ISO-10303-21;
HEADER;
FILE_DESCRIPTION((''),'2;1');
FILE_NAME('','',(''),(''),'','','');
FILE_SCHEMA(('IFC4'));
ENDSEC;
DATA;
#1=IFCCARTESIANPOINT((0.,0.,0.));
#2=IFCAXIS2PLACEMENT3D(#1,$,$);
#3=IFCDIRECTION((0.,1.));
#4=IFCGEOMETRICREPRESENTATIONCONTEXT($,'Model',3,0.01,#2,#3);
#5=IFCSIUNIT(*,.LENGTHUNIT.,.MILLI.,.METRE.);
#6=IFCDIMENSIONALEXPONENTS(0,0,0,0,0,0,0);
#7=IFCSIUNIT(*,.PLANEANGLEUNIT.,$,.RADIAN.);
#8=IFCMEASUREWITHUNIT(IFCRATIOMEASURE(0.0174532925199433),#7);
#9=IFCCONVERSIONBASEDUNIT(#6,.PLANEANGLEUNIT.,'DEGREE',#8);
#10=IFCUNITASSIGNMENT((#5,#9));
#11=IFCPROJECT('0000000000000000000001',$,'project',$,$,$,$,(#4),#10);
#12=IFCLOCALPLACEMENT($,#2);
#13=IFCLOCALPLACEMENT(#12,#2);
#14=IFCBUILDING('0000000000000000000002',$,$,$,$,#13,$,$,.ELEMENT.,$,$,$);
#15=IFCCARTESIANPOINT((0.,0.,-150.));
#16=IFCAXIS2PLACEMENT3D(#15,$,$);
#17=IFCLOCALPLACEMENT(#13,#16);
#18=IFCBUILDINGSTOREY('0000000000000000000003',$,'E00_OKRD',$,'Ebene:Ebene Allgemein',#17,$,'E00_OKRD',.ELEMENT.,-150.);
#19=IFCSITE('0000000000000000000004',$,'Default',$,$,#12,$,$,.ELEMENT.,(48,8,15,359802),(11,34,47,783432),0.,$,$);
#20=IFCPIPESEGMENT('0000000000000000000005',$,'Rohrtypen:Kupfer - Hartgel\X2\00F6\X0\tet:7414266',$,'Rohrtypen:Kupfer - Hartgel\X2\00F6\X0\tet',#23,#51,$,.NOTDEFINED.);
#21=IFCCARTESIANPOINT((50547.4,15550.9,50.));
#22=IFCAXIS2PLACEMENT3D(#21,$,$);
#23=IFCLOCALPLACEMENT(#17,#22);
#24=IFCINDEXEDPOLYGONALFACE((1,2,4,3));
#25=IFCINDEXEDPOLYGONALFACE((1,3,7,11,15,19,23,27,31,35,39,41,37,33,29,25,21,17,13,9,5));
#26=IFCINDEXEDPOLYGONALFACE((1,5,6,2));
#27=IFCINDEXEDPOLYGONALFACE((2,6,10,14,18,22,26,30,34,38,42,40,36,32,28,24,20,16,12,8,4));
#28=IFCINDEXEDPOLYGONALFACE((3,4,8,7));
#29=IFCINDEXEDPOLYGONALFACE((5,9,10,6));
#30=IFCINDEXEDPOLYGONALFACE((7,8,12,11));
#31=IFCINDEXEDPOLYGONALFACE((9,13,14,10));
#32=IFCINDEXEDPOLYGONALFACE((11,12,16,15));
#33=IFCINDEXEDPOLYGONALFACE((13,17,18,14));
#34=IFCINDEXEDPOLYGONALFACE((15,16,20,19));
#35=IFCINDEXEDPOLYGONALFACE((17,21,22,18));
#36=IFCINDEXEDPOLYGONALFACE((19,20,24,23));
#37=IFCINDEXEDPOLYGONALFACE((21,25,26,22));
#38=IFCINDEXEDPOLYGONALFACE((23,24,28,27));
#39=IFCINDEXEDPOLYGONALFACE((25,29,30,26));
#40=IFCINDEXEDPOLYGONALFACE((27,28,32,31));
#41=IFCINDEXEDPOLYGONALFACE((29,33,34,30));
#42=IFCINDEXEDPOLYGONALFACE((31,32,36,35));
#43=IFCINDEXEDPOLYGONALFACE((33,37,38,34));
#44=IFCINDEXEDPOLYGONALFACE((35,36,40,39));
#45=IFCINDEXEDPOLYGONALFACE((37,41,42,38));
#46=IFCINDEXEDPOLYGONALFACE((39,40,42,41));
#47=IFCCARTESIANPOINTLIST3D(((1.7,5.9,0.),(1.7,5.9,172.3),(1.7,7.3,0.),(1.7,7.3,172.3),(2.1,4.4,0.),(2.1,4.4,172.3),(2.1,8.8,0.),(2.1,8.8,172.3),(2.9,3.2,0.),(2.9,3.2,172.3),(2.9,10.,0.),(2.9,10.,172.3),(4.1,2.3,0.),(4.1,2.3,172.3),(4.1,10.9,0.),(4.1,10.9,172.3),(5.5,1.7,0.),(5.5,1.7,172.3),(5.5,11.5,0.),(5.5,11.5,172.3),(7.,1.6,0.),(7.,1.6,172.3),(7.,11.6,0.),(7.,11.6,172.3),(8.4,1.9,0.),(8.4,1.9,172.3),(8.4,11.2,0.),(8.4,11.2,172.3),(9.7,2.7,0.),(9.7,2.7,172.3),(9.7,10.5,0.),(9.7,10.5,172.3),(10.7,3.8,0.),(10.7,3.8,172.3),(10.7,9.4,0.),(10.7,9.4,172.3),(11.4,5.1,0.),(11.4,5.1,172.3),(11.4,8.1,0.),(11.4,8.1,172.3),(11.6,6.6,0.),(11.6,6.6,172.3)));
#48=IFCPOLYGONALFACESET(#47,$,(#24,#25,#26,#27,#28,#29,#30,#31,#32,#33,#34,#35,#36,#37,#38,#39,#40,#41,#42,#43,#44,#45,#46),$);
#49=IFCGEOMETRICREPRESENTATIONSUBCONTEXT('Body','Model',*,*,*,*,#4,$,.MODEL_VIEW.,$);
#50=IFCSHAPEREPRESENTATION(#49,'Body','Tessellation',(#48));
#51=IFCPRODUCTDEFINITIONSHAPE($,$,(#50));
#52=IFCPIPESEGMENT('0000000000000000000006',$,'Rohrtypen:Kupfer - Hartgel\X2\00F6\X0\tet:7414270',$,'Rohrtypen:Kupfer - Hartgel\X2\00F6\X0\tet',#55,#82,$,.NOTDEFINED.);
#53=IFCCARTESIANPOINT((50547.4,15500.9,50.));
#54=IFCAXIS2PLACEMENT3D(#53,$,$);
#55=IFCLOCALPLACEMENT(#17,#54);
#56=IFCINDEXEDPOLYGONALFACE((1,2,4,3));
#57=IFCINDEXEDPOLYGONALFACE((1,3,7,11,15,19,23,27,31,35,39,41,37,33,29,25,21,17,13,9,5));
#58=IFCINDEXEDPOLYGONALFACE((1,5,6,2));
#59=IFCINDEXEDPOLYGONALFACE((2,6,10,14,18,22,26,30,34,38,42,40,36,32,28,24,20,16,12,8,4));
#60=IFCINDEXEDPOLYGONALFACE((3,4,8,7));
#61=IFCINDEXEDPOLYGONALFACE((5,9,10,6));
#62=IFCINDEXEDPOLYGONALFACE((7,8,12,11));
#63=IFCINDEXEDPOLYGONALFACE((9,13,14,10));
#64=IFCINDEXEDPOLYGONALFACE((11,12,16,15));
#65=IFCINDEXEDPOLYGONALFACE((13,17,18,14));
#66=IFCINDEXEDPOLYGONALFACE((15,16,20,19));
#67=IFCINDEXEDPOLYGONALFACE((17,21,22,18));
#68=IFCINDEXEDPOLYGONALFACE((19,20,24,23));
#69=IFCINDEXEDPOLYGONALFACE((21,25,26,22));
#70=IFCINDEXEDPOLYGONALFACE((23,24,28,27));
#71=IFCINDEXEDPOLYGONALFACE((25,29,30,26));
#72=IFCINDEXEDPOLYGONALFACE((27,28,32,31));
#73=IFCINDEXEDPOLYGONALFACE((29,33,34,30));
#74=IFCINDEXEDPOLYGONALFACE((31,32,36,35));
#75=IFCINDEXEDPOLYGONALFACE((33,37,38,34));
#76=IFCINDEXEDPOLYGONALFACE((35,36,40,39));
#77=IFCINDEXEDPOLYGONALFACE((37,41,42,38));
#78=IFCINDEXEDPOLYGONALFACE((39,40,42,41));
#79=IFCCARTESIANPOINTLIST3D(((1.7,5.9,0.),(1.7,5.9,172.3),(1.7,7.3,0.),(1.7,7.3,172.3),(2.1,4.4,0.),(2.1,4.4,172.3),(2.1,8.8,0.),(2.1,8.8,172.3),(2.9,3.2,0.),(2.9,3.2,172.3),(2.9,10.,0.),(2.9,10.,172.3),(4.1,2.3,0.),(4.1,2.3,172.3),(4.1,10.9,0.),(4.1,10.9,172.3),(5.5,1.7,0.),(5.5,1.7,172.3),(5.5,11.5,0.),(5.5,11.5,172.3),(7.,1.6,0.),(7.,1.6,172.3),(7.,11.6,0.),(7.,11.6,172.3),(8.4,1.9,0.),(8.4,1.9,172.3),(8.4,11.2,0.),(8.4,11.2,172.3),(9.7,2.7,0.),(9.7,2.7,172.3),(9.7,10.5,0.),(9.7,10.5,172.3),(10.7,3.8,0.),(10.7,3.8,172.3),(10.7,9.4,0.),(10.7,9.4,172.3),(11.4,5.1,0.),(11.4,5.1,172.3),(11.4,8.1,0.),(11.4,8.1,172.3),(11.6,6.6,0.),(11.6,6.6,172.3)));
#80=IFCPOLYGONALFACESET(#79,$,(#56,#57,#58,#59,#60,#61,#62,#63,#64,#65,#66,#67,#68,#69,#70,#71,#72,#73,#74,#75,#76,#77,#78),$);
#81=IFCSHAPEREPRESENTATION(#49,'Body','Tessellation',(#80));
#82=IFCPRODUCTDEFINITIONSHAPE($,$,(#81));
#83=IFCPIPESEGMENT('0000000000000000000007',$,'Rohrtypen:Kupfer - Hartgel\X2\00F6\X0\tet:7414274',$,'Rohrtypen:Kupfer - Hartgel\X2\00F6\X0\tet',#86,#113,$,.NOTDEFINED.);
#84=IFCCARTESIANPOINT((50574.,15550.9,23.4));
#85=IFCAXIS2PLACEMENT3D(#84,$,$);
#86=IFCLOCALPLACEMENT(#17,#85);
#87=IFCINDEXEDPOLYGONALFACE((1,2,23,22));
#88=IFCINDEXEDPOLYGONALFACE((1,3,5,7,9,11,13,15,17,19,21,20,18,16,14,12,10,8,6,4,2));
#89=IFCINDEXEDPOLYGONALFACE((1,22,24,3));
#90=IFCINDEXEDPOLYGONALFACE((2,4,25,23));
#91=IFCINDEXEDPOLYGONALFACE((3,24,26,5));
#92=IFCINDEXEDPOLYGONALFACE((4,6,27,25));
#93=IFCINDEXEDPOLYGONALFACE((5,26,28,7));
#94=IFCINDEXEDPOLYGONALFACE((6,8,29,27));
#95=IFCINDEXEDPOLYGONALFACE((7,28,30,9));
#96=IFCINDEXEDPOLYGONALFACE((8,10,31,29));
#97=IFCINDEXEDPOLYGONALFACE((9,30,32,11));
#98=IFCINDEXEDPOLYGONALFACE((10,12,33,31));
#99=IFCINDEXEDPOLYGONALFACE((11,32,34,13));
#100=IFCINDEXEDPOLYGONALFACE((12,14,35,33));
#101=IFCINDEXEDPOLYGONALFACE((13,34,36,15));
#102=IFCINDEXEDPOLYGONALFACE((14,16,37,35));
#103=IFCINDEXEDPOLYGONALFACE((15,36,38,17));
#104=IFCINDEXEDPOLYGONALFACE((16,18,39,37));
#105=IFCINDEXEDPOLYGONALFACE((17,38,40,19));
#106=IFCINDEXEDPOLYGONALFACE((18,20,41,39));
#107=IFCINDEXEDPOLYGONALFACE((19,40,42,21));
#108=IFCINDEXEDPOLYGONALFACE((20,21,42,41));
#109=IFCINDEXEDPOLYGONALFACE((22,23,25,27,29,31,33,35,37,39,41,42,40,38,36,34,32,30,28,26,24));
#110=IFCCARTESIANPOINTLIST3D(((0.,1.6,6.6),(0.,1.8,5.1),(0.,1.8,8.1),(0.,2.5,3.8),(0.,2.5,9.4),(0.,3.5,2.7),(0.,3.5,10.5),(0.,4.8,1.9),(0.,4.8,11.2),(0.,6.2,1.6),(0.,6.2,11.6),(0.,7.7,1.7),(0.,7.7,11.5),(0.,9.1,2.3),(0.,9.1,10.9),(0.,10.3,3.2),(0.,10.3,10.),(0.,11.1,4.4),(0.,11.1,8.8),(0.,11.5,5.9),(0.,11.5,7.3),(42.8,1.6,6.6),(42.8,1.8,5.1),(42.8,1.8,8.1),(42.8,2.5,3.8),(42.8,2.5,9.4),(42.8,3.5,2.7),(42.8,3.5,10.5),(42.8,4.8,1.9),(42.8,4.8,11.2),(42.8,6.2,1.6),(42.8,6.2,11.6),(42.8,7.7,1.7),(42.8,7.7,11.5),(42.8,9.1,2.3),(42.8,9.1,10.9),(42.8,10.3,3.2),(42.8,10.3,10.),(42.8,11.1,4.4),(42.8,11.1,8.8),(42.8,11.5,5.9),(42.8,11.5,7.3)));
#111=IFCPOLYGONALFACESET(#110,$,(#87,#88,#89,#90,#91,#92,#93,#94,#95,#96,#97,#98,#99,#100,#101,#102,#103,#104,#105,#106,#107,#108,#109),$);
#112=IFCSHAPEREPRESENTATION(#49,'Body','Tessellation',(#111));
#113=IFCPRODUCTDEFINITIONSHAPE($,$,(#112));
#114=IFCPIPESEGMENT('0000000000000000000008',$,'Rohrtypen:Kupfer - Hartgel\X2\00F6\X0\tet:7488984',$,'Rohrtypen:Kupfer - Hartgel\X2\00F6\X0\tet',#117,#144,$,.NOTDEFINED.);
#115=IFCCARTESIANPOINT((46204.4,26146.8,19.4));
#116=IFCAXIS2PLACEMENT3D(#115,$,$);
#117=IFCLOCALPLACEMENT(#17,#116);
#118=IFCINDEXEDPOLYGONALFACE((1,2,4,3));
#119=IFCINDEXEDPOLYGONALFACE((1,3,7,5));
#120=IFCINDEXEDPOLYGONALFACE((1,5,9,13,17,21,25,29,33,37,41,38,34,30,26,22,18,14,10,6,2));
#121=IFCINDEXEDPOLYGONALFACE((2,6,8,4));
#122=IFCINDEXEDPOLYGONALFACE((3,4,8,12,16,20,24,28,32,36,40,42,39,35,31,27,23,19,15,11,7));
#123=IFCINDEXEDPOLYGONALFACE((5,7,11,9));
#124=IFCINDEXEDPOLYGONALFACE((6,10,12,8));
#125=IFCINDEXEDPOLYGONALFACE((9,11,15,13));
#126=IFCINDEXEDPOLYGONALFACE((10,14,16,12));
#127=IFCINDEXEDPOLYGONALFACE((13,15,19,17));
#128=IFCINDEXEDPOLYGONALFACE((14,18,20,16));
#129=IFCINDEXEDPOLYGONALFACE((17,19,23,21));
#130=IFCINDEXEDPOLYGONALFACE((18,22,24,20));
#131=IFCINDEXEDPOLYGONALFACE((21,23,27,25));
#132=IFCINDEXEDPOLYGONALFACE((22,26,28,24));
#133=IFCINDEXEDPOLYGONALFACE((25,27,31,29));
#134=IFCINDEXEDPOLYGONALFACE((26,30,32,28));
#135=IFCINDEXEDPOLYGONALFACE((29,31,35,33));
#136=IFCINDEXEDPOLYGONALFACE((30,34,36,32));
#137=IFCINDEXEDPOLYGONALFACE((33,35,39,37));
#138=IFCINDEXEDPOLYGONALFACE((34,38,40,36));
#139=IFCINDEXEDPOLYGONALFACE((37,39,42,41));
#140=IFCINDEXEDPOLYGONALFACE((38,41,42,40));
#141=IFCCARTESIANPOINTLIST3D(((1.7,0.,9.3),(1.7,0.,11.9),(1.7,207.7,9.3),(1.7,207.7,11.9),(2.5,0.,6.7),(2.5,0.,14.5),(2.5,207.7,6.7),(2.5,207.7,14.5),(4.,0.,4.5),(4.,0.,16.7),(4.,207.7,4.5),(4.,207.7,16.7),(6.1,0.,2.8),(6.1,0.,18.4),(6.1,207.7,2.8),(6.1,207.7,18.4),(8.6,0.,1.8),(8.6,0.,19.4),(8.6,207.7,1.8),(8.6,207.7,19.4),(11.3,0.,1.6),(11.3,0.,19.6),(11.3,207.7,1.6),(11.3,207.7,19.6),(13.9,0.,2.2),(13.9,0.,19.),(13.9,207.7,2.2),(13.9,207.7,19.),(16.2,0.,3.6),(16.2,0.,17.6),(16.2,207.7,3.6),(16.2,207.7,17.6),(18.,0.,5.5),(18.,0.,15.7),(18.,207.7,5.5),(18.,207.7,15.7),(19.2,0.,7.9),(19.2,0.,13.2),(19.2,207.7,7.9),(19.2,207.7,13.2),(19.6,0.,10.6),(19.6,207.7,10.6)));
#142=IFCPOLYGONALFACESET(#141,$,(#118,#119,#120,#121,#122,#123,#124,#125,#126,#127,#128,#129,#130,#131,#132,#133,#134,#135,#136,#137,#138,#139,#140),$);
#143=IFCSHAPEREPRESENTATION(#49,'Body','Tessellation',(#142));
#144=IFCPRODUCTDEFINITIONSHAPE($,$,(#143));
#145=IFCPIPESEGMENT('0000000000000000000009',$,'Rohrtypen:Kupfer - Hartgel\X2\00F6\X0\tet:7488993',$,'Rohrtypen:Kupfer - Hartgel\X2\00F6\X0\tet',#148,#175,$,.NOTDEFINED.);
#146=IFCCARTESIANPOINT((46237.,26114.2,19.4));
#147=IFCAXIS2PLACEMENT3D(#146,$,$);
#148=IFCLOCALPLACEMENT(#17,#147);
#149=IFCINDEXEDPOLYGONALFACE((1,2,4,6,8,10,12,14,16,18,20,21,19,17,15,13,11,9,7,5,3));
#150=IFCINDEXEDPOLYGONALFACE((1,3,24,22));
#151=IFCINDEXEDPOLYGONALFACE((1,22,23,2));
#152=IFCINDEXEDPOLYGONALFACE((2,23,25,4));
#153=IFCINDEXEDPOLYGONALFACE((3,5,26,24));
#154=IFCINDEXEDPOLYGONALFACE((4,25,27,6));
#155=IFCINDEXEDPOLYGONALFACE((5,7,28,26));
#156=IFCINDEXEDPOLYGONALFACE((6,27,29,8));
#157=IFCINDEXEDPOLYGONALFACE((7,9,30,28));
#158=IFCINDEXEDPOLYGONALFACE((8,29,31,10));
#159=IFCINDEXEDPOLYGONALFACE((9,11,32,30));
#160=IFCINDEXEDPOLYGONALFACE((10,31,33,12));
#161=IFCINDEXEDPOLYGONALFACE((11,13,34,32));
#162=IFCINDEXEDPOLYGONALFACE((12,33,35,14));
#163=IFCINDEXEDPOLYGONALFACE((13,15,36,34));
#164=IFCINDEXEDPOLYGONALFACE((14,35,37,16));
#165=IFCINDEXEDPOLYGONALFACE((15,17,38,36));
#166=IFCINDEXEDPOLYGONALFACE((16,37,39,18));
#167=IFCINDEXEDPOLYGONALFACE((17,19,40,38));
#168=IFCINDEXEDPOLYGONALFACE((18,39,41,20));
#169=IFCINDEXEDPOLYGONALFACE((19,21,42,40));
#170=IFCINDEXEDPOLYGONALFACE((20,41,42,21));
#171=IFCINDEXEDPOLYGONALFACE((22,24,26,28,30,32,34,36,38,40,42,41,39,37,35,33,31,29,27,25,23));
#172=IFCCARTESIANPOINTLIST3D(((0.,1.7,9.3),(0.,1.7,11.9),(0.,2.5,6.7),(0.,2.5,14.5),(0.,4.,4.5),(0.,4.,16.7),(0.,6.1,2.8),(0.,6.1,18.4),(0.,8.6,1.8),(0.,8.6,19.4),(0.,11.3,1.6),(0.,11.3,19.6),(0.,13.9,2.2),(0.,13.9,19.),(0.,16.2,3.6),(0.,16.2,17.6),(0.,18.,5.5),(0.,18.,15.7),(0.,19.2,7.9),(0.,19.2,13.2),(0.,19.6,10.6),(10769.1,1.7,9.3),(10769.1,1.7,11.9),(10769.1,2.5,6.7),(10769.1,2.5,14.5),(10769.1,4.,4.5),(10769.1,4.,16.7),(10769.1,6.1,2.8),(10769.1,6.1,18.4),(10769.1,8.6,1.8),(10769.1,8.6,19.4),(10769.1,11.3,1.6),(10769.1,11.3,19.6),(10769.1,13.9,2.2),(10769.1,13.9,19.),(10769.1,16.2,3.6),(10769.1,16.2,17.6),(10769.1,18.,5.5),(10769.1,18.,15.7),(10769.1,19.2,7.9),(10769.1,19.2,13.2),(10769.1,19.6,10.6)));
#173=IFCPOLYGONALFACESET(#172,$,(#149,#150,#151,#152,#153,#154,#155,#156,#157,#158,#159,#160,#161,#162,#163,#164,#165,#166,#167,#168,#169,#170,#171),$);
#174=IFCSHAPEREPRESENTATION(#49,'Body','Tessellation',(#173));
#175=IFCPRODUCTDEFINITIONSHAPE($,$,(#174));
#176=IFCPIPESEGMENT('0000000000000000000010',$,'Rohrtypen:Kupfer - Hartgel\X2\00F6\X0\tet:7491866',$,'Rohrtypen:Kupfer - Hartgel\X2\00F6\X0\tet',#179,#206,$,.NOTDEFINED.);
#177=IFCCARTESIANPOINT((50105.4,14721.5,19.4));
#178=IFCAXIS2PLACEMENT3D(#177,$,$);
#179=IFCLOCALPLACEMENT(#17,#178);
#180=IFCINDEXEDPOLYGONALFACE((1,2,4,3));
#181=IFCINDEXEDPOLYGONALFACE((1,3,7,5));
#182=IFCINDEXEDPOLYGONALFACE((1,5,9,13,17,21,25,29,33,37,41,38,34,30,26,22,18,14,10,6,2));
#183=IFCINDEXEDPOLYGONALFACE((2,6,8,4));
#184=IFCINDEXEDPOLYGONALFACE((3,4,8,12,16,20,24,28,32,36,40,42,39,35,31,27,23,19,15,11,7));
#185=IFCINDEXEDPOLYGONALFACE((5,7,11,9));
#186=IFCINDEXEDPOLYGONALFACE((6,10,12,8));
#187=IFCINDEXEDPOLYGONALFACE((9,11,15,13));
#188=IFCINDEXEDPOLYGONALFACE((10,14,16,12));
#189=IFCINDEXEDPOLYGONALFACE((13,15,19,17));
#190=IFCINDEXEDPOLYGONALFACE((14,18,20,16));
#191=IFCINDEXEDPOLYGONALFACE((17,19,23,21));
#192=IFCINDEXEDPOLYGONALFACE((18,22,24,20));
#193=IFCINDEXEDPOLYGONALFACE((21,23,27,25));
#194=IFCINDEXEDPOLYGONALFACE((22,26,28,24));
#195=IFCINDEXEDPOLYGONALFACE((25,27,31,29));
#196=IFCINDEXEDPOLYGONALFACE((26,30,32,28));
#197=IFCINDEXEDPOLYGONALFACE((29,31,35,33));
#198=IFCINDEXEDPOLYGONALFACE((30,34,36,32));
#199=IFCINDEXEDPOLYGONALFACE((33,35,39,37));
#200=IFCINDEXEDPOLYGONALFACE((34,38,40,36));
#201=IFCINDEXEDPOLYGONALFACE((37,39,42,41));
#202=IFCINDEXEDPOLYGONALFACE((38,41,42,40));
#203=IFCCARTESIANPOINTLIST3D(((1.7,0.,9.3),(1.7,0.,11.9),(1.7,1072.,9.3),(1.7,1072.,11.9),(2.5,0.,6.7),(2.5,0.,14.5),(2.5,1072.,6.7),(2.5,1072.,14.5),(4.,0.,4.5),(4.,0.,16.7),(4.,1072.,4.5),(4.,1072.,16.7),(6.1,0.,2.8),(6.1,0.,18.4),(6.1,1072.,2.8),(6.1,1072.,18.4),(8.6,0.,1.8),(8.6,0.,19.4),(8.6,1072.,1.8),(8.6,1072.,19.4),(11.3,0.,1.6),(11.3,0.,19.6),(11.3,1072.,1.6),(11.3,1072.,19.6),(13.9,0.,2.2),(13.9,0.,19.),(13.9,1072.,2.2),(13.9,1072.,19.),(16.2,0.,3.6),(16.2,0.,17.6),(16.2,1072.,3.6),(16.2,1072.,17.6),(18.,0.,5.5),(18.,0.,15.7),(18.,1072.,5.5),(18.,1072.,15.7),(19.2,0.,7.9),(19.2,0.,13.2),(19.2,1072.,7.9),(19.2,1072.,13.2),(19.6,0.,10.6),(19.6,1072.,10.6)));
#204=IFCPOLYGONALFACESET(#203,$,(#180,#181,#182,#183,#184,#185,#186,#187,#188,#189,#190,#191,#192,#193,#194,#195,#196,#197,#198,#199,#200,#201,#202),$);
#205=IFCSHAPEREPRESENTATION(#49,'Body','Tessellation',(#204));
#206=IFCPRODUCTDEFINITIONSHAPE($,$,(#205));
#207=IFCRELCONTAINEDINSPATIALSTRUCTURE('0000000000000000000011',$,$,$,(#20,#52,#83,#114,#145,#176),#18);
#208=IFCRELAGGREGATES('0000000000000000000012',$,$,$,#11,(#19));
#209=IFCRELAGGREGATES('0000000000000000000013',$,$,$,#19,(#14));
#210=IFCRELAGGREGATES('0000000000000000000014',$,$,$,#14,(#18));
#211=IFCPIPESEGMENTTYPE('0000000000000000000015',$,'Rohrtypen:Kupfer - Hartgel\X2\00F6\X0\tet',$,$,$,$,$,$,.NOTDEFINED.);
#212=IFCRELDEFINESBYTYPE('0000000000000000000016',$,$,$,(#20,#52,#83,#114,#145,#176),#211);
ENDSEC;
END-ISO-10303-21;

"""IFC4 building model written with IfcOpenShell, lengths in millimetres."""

from ifc_helpers import new_model, entity, si_unit, converted_unit, direction, frame, frame_2d, origin, origin_2d_with_axis, place, context, subcontext, project, spatial, circle, extrude, type_object, element, save


model = new_model("IFC4")

# Units and contexts
model_context = context("Model", 3, precision=0.01, world=origin(), true_north=direction((0.0, 1.0)))
body_context = subcontext(model_context, "Body", "Model", "MODEL_VIEW")
ifc_project = project(units=[si_unit("LENGTHUNIT", "METRE", prefix="MILLI"), converted_unit("PLANEANGLEUNIT", "DEGREE", entity("IfcRatioMeasure", 0.0174532925199433), si_unit("PLANEANGLEUNIT", "RADIAN"), dimensions=[0, 0, 0, 0, 0, 0, 0])], contexts=[model_context])

# Site, building, storey
site_placement = place(None, origin())
site = spatial("IfcSite", under=ifc_project, at=site_placement, Name="Default", CompositionType="ELEMENT", RefLatitude=(48, 8, 15, 359802), RefLongitude=(11, 34, 47, 783432), RefElevation=0.0)
building_placement = place(site_placement, origin())
building = spatial("IfcBuilding", under=site, at=building_placement, CompositionType="ELEMENT")
storey_placement = place(building_placement, frame((0.0, 0.0, -150.0)))
storey = spatial("IfcBuildingStorey", under=building, at=storey_placement, Name="E00_OKRD", ObjectType="Ebene:Ebene Allgemein", LongName="E00_OKRD", CompositionType="ELEMENT", Elevation=-150.0)

# Pipe segments
pipe_segment_type = type_object("IfcPipeSegmentType", Name="Rohrtypen:Kupfer - Hartgelötet", PredefinedType="NOTDEFINED")
pipe_segment_1_placement = place(storey_placement, frame((50547.4, 15550.9, 50.0)))
element("IfcPipeSegment", 1, at=pipe_segment_1_placement, inside=storey, type_object=pipe_segment_type, Name="Rohrtypen:Kupfer - Hartgelötet:7414266", ObjectType="Rohrtypen:Kupfer - Hartgelötet", PredefinedType="NOTDEFINED", context=body_context, shape_type="SweptSolid", body=[
    extrude(circle(Radius=5.0, at=origin_2d_with_axis()), frame((6.6, 6.6, 0.0)), (0.0, 0.0, 1.0), 172.3),
])
pipe_segment_2_placement = place(storey_placement, frame((50547.4, 15500.9, 50.0)))
element("IfcPipeSegment", 2, at=pipe_segment_2_placement, inside=storey, type_object=pipe_segment_type, Name="Rohrtypen:Kupfer - Hartgelötet:7414270", ObjectType="Rohrtypen:Kupfer - Hartgelötet", PredefinedType="NOTDEFINED", context=body_context, shape_type="SweptSolid", body=[
    extrude(circle(Radius=5.0, at=origin_2d_with_axis()), frame((6.6, 6.6, 0.0)), (0.0, 0.0, 1.0), 172.3),
])
pipe_segment_3_placement = place(storey_placement, frame((50574.0, 15550.9, 23.4)))
element("IfcPipeSegment", 3, at=pipe_segment_3_placement, inside=storey, type_object=pipe_segment_type, Name="Rohrtypen:Kupfer - Hartgelötet:7414274", ObjectType="Rohrtypen:Kupfer - Hartgelötet", PredefinedType="NOTDEFINED", context=body_context, shape_type="SweptSolid", body=[
    extrude(circle(Radius=5.0, at=origin_2d_with_axis()), frame((0.0, 6.6, 6.6), z_axis=(1.0, 0.0, 0.0), x_axis=(0.0, -1.0, 0.0)), (0.0, 0.0, 1.0), 42.8),
])
pipe_segment_4_placement = place(storey_placement, frame((46204.4, 26146.8, 19.4)))
element("IfcPipeSegment", 4, at=pipe_segment_4_placement, inside=storey, type_object=pipe_segment_type, Name="Rohrtypen:Kupfer - Hartgelötet:7488984", ObjectType="Rohrtypen:Kupfer - Hartgelötet", PredefinedType="NOTDEFINED", context=body_context, shape_type="SweptSolid", body=[
    extrude(circle(Radius=9.0, at=frame_2d((0.0, 0.0), x_axis=(1.0, 0.0))), frame((10.6, 0.0, 10.6), z_axis=(0.0, 1.0, 0.0), x_axis=(1.0, 0.0, 0.0)), (0.0, 0.0, 1.0), 207.7),
])
pipe_segment_5_placement = place(storey_placement, frame((46237.0, 26114.2, 19.4)))
element("IfcPipeSegment", 5, at=pipe_segment_5_placement, inside=storey, type_object=pipe_segment_type, Name="Rohrtypen:Kupfer - Hartgelötet:7488993", ObjectType="Rohrtypen:Kupfer - Hartgelötet", PredefinedType="NOTDEFINED", context=body_context, shape_type="SweptSolid", body=[
    extrude(circle(Radius=9.0, at=frame_2d((0.0, 0.0), x_axis=(1.0, 0.0))), frame((0.0, 10.6, 10.6), z_axis=(1.0, 0.0, 0.0), x_axis=(0.0, 1.0, 0.0)), (0.0, 0.0, 1.0), 10769.1),
])
pipe_segment_6_placement = place(storey_placement, frame((50105.4, 14721.5, 19.4)))
element("IfcPipeSegment", 6, at=pipe_segment_6_placement, inside=storey, type_object=pipe_segment_type, Name="Rohrtypen:Kupfer - Hartgelötet:7491866", ObjectType="Rohrtypen:Kupfer - Hartgelötet", PredefinedType="NOTDEFINED", context=body_context, shape_type="SweptSolid", body=[
    extrude(circle(Radius=9.0, at=origin_2d_with_axis()), frame((10.6, 0.0, 10.6), z_axis=(0.0, 1.0, 0.0), x_axis=(1.0, 0.0, 0.0)), (0.0, 0.0, 1.0), 1072.0),
])

save(model, "model.ifc")
